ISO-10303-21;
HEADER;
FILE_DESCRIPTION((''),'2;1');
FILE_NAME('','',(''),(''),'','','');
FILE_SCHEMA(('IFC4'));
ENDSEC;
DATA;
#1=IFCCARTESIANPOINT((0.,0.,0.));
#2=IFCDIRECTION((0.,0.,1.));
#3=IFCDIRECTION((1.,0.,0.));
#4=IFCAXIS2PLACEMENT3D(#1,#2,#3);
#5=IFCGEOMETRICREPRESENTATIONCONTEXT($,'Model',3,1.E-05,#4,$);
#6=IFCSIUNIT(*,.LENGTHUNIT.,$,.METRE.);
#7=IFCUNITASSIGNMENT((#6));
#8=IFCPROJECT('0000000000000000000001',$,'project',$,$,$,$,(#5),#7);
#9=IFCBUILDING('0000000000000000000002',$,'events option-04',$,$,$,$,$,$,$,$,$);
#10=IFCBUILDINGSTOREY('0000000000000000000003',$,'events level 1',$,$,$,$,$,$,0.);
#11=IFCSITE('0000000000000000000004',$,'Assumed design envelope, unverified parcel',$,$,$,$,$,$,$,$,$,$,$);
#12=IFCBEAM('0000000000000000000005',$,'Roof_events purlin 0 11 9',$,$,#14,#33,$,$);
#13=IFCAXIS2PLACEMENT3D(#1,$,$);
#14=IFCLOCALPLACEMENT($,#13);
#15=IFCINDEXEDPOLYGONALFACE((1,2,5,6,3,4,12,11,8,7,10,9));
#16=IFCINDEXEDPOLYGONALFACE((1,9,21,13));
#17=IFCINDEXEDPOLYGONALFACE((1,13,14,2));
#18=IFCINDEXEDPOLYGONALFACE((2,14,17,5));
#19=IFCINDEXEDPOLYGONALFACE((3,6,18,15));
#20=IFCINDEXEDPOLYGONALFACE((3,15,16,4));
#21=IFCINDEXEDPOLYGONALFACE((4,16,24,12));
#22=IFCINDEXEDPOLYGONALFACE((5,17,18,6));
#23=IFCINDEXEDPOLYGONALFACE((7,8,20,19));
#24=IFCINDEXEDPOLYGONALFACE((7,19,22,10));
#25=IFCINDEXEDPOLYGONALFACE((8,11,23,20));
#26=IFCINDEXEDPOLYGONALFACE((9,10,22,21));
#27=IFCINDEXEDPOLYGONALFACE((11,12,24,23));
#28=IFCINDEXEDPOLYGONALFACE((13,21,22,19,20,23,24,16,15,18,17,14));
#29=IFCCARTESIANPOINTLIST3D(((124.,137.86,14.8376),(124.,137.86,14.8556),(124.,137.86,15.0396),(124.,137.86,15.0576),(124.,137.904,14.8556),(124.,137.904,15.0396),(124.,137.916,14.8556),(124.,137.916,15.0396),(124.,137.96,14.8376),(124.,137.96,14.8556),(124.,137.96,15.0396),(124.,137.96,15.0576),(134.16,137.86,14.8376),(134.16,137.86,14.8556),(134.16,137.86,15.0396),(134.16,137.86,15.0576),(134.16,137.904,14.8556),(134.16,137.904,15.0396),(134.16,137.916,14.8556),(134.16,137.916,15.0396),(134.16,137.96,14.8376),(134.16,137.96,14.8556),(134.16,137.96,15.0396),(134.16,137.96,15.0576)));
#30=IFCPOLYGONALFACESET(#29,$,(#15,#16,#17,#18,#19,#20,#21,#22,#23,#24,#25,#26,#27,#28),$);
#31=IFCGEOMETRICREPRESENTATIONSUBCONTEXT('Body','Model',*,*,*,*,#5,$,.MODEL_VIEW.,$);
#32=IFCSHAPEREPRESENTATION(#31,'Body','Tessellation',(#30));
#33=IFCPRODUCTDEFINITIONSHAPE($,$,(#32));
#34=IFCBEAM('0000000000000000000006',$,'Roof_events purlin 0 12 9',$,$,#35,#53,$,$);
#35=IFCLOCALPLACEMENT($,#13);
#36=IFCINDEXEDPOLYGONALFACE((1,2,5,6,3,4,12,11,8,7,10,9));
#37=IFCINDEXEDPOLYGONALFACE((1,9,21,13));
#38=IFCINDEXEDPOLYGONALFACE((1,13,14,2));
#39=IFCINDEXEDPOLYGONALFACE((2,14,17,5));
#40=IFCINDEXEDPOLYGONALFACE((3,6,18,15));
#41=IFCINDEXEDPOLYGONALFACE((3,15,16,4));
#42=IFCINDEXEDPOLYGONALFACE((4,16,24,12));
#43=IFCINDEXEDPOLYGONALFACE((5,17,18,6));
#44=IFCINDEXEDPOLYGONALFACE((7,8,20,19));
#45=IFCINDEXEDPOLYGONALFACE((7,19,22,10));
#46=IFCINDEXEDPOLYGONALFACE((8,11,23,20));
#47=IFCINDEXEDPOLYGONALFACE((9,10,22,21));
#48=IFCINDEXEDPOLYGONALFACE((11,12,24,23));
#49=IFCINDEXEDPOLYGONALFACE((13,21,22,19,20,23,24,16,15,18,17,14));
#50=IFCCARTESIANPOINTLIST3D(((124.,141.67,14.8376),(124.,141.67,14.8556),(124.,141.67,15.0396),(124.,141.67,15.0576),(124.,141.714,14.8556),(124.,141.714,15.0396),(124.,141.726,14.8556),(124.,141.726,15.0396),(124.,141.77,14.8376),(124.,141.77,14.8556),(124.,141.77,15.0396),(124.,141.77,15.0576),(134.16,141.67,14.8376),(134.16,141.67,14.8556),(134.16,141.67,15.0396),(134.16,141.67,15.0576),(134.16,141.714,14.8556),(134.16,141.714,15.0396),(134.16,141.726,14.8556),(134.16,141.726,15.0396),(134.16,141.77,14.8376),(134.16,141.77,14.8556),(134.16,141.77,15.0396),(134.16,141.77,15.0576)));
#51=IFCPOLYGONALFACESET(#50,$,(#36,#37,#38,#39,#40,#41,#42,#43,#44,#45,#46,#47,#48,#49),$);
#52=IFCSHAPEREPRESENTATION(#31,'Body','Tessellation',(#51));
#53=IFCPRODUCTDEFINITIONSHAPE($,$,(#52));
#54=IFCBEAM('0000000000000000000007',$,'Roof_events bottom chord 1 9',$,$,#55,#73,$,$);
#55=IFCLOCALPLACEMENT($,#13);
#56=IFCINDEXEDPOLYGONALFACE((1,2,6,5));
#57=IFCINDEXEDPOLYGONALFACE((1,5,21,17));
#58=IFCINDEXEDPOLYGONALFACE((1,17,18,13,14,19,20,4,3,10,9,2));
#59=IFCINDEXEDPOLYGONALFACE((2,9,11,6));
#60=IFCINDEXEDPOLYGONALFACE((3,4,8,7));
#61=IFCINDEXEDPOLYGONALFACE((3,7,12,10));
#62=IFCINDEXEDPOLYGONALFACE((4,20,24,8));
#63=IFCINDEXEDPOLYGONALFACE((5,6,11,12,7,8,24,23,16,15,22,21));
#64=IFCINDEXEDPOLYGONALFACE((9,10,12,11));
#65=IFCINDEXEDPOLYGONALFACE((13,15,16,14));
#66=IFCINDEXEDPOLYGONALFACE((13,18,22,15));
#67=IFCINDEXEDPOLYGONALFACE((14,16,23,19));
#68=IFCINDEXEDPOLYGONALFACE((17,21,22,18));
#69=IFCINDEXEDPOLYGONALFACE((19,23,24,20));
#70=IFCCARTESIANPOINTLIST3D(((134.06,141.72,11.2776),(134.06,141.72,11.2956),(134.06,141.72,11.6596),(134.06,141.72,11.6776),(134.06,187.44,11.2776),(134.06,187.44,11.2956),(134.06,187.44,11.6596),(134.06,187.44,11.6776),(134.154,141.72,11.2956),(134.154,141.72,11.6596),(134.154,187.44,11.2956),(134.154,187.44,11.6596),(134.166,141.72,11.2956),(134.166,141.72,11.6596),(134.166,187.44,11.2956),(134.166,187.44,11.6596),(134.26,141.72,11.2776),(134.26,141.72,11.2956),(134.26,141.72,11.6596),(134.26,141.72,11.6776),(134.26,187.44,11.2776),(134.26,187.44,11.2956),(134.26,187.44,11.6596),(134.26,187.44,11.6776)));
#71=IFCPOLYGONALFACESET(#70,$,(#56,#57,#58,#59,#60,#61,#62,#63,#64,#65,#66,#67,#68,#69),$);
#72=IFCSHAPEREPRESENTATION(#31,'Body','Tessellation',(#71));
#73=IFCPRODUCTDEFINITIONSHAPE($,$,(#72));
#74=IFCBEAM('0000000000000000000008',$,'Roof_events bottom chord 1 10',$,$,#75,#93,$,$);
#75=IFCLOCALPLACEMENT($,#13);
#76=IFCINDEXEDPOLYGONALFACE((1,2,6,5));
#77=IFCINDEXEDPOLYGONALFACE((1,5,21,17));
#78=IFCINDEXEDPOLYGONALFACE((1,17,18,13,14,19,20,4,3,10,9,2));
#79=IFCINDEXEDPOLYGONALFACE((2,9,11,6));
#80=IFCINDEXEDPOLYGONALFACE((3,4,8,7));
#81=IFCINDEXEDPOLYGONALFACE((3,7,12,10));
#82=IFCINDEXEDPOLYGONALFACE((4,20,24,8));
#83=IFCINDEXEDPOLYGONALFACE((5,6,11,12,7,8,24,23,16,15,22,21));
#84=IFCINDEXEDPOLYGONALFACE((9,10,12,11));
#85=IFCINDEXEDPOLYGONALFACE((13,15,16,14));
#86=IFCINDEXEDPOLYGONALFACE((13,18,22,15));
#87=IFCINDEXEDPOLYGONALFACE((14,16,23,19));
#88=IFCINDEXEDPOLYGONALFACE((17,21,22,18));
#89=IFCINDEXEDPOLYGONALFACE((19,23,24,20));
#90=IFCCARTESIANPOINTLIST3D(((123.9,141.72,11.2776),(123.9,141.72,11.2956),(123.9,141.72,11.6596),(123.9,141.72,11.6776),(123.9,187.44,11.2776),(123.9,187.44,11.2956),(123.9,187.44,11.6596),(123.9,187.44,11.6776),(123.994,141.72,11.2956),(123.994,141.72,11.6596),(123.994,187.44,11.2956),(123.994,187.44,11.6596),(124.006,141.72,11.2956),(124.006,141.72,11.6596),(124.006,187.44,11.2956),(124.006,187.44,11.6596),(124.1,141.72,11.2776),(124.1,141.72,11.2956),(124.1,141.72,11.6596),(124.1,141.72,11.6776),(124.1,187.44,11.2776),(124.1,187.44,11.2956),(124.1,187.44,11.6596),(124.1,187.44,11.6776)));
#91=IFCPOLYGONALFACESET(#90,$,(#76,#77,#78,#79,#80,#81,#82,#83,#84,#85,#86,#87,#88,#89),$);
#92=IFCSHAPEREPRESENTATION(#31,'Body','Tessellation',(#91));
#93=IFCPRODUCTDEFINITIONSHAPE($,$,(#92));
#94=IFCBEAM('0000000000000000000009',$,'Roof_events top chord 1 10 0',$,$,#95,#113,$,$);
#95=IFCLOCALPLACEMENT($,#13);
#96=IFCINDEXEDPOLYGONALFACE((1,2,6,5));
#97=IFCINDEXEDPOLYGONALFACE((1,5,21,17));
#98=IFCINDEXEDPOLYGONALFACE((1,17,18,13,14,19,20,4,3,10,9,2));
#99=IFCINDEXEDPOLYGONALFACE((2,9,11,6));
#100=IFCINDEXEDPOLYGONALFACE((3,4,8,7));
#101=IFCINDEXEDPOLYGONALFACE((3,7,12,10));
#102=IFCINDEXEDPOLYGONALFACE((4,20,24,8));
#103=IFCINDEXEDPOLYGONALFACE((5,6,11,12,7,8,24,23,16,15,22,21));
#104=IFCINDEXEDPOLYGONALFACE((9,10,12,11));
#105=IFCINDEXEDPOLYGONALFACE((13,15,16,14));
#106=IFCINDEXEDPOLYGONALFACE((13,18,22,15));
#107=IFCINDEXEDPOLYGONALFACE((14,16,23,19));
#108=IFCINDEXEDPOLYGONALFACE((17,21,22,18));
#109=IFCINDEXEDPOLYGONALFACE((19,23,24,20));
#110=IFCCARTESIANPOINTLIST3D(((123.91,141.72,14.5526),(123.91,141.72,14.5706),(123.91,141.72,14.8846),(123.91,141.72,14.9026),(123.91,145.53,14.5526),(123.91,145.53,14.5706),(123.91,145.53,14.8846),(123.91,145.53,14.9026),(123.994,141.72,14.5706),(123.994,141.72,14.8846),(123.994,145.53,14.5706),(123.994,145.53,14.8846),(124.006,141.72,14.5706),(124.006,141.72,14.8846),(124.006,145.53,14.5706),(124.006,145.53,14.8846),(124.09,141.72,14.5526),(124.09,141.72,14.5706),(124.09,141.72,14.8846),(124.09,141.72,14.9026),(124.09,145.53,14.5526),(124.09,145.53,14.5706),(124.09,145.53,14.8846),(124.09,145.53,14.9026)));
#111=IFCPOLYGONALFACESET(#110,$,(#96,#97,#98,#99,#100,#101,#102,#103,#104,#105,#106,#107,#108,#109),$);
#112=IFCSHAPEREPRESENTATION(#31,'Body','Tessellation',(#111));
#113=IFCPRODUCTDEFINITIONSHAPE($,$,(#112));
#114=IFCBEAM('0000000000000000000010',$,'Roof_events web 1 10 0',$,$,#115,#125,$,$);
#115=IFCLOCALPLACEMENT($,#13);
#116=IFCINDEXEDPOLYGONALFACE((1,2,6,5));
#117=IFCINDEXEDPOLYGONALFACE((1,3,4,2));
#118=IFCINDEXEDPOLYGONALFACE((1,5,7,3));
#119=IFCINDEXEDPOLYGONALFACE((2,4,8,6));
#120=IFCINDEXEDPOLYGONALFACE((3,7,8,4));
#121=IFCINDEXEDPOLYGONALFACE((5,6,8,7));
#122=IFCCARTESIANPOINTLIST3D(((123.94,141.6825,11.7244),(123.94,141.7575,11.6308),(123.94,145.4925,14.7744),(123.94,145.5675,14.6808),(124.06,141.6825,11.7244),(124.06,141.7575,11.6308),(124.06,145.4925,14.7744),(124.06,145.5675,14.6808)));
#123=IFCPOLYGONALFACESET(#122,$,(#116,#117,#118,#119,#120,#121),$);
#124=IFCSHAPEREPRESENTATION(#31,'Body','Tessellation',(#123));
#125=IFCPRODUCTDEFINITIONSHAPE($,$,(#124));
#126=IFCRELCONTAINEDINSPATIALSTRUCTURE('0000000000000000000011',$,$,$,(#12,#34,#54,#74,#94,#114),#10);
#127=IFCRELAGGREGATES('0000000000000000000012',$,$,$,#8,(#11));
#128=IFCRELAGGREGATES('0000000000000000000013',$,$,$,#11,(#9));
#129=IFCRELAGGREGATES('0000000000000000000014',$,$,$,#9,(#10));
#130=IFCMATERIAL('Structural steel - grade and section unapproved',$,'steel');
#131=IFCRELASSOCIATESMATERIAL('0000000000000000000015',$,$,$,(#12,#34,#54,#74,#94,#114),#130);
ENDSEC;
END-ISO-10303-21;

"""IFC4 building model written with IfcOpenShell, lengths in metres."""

from ifc_helpers import new_model, si_unit, frame, origin_with_axes, place, context, subcontext, project, spatial, rectangle, i_section, extrude, material, element, save


model = new_model("IFC4")

# Units and contexts
model_context = context("Model", 3, precision=1e-05, world=origin_with_axes())
body_context = subcontext(model_context, "Body", "Model", "MODEL_VIEW")
ifc_project = project(units=[si_unit("LENGTHUNIT", "METRE")], contexts=[model_context])

# Site, building, storey
site = spatial("IfcSite", under=ifc_project, Name="Assumed design envelope, unverified parcel")
building = spatial("IfcBuilding", under=site, Name="events option-04")
storey = spatial("IfcBuildingStorey", under=building, Name="events level 1", Elevation=0.0)

# Shared definitions
ifc_material = material(Name="Structural steel - grade and section unapproved", Category="steel")

# Beams
for number, where, z_axis, x_axis, name in (
    (1, (134.16, 137.91, 14.9476), (-1.0, 0.0, 0.0), (0.0, -1.0, 0.0), "Roof_events purlin 0 11 9"),
    (2, (134.16, 141.72, 14.9476), (-1.0, 0.0, 0.0), (0.0, -1.0, 0.0), "Roof_events purlin 0 12 9"),
):
    element("IfcBeam", number, at=place(None, frame(where, z_axis=z_axis, x_axis=x_axis)), inside=storey, material=ifc_material, Name=name, context=body_context, shape_type="SweptSolid", body=[
        extrude(i_section(OverallWidth=0.1, OverallDepth=0.22, WebThickness=0.012, FlangeThickness=0.018, FilletRadius=0.0), origin_with_axes(), (0.0, 0.0, 1.0), 10.16),
    ])
for number, where, z_axis, x_axis, name in (
    (3, (134.16, 141.72, 11.4776), (0.0, 1.0, 0.0), (-1.0, 0.0, 0.0), "Roof_events bottom chord 1 9"),
    (4, (124.0, 141.72, 11.4776), (0.0, 1.0, 0.0), (-1.0, 0.0, 0.0), "Roof_events bottom chord 1 10"),
):
    element("IfcBeam", number, at=place(None, frame(where, z_axis=z_axis, x_axis=x_axis)), inside=storey, material=ifc_material, Name=name, context=body_context, shape_type="SweptSolid", body=[
        extrude(i_section(OverallWidth=0.2, OverallDepth=0.4, WebThickness=0.012, FlangeThickness=0.018, FilletRadius=0.0), origin_with_axes(), (0.0, 0.0, 1.0), 45.72),
    ])
beam_1_placement = place(None, frame((124.0, 141.72, 14.7276), z_axis=(0.0, 1.0, 0.0), x_axis=(-1.0, 0.0, 0.0)))
element("IfcBeam", 5, at=beam_1_placement, inside=storey, material=ifc_material, Name="Roof_events top chord 1 10 0", context=body_context, shape_type="SweptSolid", body=[
    extrude(i_section(OverallWidth=0.18, OverallDepth=0.35, WebThickness=0.012, FlangeThickness=0.018, FilletRadius=0.0), origin_with_axes(), (0.0, 0.0, 1.0), 3.81),
])
beam_2_placement = place(None, frame((124.0, 141.72, 11.6776), z_axis=(0.0, 0.780669, 0.624945), x_axis=(-1.0, 0.0, 0.0)))
element("IfcBeam", 6, at=beam_2_placement, inside=storey, material=ifc_material, Name="Roof_events web 1 10 0", context=body_context, shape_type="SweptSolid", body=[
    extrude(rectangle(XDim=0.12, YDim=0.12), origin_with_axes(), (0.0, 0.0, 1.0), 4.8804),
])

save(model, "model.ifc")
